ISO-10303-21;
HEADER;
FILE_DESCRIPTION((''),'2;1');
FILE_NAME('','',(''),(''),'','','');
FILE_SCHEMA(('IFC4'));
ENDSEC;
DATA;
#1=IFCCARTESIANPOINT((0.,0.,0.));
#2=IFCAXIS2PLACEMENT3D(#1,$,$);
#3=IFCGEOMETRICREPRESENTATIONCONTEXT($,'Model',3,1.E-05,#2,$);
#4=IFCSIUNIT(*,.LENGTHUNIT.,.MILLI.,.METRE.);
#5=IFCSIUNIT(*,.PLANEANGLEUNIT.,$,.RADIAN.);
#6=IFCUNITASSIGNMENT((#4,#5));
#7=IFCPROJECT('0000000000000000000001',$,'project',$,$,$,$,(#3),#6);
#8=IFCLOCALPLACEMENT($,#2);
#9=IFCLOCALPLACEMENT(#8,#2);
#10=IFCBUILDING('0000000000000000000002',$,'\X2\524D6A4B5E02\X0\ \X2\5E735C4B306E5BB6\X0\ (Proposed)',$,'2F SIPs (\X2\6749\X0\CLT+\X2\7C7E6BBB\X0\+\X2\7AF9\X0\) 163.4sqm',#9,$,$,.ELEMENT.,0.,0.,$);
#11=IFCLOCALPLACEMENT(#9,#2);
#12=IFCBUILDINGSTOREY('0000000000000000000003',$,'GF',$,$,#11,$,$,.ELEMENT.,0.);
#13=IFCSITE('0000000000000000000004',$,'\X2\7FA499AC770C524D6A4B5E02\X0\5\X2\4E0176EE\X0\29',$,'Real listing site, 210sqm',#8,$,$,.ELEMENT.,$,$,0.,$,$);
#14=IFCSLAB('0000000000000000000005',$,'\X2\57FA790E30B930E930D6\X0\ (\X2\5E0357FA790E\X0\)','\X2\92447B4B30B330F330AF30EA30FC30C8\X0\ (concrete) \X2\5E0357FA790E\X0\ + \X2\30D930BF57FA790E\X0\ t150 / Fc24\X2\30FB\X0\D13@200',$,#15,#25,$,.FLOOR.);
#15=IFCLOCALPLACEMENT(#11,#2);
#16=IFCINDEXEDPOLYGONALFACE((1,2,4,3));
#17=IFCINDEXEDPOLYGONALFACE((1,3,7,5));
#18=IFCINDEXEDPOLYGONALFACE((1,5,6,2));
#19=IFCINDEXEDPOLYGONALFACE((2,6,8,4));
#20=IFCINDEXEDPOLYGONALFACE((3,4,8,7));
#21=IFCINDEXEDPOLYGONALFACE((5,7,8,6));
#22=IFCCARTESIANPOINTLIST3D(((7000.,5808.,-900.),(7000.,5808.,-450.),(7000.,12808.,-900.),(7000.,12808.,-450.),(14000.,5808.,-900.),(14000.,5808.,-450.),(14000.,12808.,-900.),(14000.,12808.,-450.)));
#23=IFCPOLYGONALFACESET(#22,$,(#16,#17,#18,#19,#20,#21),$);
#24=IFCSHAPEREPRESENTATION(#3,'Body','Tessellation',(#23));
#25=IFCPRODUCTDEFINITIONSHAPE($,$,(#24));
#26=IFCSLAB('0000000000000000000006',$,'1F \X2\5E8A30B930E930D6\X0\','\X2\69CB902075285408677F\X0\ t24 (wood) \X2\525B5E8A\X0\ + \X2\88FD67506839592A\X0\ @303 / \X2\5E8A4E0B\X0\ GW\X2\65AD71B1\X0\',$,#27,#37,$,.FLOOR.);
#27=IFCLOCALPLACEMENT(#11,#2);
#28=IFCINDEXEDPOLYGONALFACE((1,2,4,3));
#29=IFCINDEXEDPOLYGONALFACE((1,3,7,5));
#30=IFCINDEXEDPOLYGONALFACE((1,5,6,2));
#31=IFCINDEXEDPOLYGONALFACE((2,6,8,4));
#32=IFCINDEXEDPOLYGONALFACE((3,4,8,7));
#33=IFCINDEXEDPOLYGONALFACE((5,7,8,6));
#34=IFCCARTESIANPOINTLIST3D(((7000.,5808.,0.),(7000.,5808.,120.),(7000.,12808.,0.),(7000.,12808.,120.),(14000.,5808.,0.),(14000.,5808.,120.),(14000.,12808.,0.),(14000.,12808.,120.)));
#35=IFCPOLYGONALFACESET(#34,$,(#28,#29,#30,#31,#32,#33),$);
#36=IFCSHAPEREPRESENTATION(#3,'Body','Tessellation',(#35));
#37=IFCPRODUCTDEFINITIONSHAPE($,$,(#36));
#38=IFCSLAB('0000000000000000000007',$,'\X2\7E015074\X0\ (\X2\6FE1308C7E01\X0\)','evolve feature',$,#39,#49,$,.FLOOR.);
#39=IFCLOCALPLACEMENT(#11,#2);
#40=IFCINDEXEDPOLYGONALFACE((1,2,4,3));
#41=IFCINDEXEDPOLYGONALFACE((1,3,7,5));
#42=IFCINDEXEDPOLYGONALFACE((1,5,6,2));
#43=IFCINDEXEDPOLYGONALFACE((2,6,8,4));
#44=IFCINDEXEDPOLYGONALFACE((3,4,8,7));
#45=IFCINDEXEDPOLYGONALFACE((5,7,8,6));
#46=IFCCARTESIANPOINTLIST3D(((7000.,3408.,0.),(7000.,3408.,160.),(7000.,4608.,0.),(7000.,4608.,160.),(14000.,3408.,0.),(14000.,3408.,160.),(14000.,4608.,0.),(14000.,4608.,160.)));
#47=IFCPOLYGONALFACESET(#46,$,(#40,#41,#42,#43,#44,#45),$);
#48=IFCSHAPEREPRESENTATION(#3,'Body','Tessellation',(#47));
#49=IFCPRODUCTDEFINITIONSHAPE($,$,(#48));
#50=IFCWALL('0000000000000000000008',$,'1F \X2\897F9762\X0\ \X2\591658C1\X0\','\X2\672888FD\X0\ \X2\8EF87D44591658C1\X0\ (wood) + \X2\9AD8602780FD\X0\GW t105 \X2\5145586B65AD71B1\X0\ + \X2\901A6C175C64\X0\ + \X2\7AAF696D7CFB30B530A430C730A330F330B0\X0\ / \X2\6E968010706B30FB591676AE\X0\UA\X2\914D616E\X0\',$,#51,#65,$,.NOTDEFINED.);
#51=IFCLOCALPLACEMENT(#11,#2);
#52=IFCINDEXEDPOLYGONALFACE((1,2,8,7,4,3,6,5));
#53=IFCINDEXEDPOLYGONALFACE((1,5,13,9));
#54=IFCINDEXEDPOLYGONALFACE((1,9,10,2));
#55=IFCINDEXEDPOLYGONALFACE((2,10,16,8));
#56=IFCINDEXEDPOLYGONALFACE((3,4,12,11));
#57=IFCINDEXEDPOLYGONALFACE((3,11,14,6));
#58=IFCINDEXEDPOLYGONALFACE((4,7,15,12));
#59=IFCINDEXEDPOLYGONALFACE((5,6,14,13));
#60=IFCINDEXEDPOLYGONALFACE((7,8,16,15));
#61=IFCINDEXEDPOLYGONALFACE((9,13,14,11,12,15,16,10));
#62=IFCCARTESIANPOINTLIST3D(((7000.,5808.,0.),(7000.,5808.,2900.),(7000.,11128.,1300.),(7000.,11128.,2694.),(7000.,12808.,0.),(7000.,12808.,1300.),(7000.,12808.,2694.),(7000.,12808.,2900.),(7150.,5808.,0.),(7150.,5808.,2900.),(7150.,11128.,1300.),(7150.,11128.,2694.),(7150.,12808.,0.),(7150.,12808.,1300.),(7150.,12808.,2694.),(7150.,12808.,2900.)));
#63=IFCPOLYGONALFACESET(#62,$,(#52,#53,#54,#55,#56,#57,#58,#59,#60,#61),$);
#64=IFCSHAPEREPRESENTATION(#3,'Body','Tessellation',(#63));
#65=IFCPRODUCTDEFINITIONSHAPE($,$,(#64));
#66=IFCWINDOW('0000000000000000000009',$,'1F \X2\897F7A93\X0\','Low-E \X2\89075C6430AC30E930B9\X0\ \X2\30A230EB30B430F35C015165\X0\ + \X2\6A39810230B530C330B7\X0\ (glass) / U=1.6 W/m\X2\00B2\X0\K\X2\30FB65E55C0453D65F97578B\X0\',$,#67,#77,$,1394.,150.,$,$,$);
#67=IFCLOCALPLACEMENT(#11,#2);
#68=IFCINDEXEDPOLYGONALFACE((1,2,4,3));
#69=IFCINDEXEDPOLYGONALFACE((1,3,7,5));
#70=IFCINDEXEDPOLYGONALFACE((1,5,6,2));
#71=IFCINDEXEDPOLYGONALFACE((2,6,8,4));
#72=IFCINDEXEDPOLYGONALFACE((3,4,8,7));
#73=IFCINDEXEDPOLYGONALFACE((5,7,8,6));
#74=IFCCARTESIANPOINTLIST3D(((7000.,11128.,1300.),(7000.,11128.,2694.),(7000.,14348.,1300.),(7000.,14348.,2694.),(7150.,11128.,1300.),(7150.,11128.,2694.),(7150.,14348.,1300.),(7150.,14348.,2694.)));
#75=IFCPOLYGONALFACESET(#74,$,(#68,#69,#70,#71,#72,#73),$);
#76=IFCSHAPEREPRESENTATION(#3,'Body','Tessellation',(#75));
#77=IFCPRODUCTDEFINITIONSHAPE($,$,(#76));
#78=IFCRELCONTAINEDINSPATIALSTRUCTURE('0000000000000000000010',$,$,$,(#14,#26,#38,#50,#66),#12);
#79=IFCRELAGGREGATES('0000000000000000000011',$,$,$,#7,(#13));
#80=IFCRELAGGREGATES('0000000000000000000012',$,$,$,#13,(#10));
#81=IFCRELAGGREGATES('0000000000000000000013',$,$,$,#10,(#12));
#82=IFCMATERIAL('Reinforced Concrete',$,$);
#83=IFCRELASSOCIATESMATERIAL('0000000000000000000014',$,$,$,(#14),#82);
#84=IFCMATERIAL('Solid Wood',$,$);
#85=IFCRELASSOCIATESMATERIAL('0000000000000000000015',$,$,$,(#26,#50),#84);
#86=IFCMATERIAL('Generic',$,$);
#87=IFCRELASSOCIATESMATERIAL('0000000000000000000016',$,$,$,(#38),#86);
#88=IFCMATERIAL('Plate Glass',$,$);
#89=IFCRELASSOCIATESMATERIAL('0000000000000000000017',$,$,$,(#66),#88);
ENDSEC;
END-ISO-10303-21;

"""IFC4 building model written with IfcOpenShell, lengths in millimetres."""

from ifc_helpers import new_model, si_unit, frame, frame_2d, origin, place, context, project, spatial, rectangle, extrude, material, element, fill, save


model = new_model("IFC4")

# Units and contexts
model_context = context("Model", 3, precision=1e-05, world=origin())
ifc_project = project(units=[si_unit("LENGTHUNIT", "METRE", prefix="MILLI"), si_unit("PLANEANGLEUNIT", "RADIAN")], contexts=[model_context])

# Site, building, storey
site_placement = place(None, origin())
site = spatial("IfcSite", under=ifc_project, at=site_placement, Name="群馬県前橋市5丁目29", ObjectType="Real listing site, 210sqm", CompositionType="ELEMENT", RefElevation=0.0)
building_placement = place(site_placement, origin())
building = spatial("IfcBuilding", under=site, at=building_placement, Name="前橋市 平屋の家 (Proposed)", ObjectType="2F SIPs (杉CLT+籾殻+竹) 163.4sqm", CompositionType="ELEMENT", ElevationOfRefHeight=0.0, ElevationOfTerrain=0.0)
storey_placement = place(building_placement, origin())
storey = spatial("IfcBuildingStorey", under=building, at=storey_placement, Name="GF", CompositionType="ELEMENT", Elevation=0.0)

# Slabs
ifc_material_1 = material(Name="Reinforced Concrete")
slab_1_placement = place(storey_placement, frame((3500.0, 2904.0, -450.0)))
element("IfcSlab", 1, at=slab_1_placement, inside=storey, material=ifc_material_1, Name="基礎スラブ (布基礎)", Description="鉄筋コンクリート (concrete) 布基礎 + ベタ基礎 t150 / Fc24・D13@200", PredefinedType="FLOOR", context=model_context, shape_type="SweptSolid", body=[
    extrude(rectangle(XDim=7000.0, YDim=7000.0, at=frame_2d((3500.0, 3500.0))), frame((3500.0, 2904.0, -450.0)), (0.0, 0.0, 1.0), 450.0),
])
ifc_material_2 = material(Name="Solid Wood")
slab_2_placement = place(storey_placement, frame((3500.0, 2904.0, 0.0)))
element("IfcSlab", 2, at=slab_2_placement, inside=storey, material=ifc_material_2, Name="1F 床スラブ", Description="構造用合板 t24 (wood) 剛床 + 製材根太 @303 / 床下 GW断熱", PredefinedType="FLOOR", context=model_context, shape_type="SweptSolid", body=[
    extrude(rectangle(XDim=7000.0, YDim=7000.0, at=frame_2d((3500.0, 3500.0))), frame((3500.0, 2904.0, 0.0)), (0.0, 0.0, 1.0), 120.0),
])
ifc_material_3 = material(Name="Generic")
slab_3_placement = place(storey_placement, frame((3500.0, 1704.0, 0.0)))
element("IfcSlab", 3, at=slab_3_placement, inside=storey, material=ifc_material_3, Name="縁側 (濡れ縁)", Description="evolve feature", PredefinedType="FLOOR", context=model_context, shape_type="SweptSolid", body=[
    extrude(rectangle(XDim=7000.0, YDim=1200.0, at=frame_2d((3500.0, 600.0))), frame((3500.0, 1704.0, 0.0)), (0.0, 0.0, 1.0), 160.0),
])

# Shared definitions
ifc_material_4 = material(Name="Plate Glass")

# Wall, opening, window
wall_1_placement = place(storey_placement, frame((3500.0, 2904.0, 0.0)))
wall_1 = element("IfcWall", 4, at=wall_1_placement, inside=storey, material=ifc_material_2, Name="1F 西面 外壁", Description="木製 軸組外壁 (wood) + 高性能GW t105 充填断熱 + 通気層 + 窯業系サイディング / 準耐火・外皮UA配慮", PredefinedType="NOTDEFINED", context=model_context, shape_type="SweptSolid", body=[
    extrude(rectangle(XDim=150.0, YDim=7000.0, at=frame_2d((75.0, 3500.0))), frame((3500.0, 2904.0, 0.0)), (0.0, 0.0, 1.0), 2900.0),
])
opening_1_placement = place(storey_placement, frame((3500.0, 5564.0, 650.0)))
opening_1 = element("IfcOpeningElement", 5, at=opening_1_placement, cuts=wall_1, PredefinedType="NOTDEFINED", context=model_context, shape_type="SweptSolid", body=[
    extrude(rectangle(XDim=150.0, YDim=3220.0, at=frame_2d((75.0, 1610.0))), frame((3500.0, 5564.0, 650.0)), (0.0, 0.0, 1.0), 1394.0),
])
window_1_placement = place(storey_placement, frame((3500.0, 5564.0, 650.0)))
window_1 = element("IfcWindow", 6, at=window_1_placement, inside=storey, material=ifc_material_4, Name="1F 西窓", Description="Low-E 複層ガラス アルゴン封入 + 樹脂サッシ (glass) / U=1.6 W/m²K・日射取得型", OverallHeight=1394.0, OverallWidth=150.0, context=model_context, shape_type="SweptSolid", body=[
    extrude(rectangle(XDim=150.0, YDim=3220.0, at=frame_2d((75.0, 1610.0))), frame((3500.0, 5564.0, 650.0)), (0.0, 0.0, 1.0), 1394.0),
])
fill(opening_1, window_1)

save(model, "model.ifc")
